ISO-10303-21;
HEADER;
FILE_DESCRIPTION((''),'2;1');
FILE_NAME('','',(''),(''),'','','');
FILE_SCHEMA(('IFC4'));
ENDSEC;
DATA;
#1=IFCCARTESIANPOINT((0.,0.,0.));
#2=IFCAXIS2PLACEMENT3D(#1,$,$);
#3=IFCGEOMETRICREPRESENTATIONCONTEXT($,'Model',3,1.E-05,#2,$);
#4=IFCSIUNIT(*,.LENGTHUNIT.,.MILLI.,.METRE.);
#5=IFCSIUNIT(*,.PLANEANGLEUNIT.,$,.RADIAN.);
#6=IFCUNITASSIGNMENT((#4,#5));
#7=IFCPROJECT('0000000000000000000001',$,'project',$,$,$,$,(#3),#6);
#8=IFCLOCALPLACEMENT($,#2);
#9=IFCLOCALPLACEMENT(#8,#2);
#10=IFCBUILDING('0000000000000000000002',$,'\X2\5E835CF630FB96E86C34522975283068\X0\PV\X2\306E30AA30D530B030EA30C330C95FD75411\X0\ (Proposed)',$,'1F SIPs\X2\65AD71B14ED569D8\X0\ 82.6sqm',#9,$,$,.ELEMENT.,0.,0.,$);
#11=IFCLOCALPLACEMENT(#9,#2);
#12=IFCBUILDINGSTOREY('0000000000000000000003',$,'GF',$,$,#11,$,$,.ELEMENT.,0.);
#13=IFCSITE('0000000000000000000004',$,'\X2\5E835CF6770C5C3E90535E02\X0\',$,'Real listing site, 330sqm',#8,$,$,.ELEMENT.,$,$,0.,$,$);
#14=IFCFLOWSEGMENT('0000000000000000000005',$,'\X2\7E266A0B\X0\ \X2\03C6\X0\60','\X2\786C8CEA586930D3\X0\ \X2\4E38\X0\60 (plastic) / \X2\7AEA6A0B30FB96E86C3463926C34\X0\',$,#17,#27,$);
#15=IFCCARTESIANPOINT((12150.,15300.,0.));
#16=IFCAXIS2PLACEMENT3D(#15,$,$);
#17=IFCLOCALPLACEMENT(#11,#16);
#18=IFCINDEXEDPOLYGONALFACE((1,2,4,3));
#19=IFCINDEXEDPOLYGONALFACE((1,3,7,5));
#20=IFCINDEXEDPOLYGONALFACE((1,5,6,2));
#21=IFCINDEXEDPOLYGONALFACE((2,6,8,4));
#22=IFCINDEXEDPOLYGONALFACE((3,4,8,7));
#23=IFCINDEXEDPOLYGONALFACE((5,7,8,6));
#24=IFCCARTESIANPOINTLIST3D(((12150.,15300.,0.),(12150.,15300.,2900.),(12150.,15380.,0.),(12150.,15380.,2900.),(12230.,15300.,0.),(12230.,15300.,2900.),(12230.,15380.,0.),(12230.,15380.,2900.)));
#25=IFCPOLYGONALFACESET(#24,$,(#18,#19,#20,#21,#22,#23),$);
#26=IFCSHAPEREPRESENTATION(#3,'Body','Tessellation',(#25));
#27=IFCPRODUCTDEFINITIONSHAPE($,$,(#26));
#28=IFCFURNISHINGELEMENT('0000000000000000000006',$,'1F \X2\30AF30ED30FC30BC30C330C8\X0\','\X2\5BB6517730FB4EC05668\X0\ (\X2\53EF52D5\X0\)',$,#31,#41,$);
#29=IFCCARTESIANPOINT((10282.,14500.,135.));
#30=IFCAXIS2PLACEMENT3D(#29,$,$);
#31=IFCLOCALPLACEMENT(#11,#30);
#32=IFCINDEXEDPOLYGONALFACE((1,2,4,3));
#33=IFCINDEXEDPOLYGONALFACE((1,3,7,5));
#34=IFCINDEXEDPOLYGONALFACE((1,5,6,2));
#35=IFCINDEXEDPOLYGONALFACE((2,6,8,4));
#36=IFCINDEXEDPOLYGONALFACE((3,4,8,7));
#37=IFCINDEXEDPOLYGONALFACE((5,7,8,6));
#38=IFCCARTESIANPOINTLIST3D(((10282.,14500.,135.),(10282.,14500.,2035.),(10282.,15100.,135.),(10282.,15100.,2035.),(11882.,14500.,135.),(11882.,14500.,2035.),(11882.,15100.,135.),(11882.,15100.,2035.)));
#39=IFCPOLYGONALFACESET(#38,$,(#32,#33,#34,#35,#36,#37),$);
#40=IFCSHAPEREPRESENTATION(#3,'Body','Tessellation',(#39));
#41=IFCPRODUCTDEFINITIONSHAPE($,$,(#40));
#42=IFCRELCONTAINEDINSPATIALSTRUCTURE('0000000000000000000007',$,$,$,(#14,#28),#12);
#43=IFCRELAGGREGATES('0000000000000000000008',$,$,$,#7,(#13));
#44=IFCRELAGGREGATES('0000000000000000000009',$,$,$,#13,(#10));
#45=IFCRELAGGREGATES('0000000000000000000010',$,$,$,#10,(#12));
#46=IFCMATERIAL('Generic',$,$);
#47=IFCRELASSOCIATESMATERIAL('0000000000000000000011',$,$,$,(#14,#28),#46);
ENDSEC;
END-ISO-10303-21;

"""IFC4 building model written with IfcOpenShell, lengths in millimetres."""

from ifc_helpers import new_model, si_unit, frame, frame_2d, origin, place, context, project, spatial, rectangle, extrude, material, element, save


model = new_model("IFC4")

# Units and contexts
model_context = context("Model", 3, precision=1e-05, world=origin())
ifc_project = project(units=[si_unit("LENGTHUNIT", "METRE", prefix="MILLI"), si_unit("PLANEANGLEUNIT", "RADIAN")], contexts=[model_context])

# Site, building, storey
site_placement = place(None, origin())
site = spatial("IfcSite", under=ifc_project, at=site_placement, Name="広島県尾道市", ObjectType="Real listing site, 330sqm", CompositionType="ELEMENT", RefElevation=0.0)
building_placement = place(site_placement, origin())
building = spatial("IfcBuilding", under=site, at=building_placement, Name="広島・雨水利用とPVのオフグリッド志向 (Proposed)", ObjectType="1F SIPs断熱仕様 82.6sqm", CompositionType="ELEMENT", ElevationOfRefHeight=0.0, ElevationOfTerrain=0.0)
storey_placement = place(building_placement, origin())
storey = spatial("IfcBuildingStorey", under=building, at=storey_placement, Name="GF", CompositionType="ELEMENT", Elevation=0.0)

# Shared definitions
ifc_material_1 = material(Name="Generic")

# Flow segment
flow_segment_placement = place(storey_placement, frame((12150.0, 15300.0, 0.0)))
element("IfcFlowSegment", 1, at=flow_segment_placement, inside=storey, material=ifc_material_1, Name="縦樋 φ60", Description="硬質塩ビ 丸60 (plastic) / 竪樋・雨水排水", context=model_context, shape_type="SweptSolid", body=[
    extrude(rectangle(XDim=80.0, YDim=80.0, at=frame_2d((40.0, 40.0))), frame((12150.0, 15300.0, 0.0)), (0.0, 0.0, 1.0), 2900.0),
])

# Furnishing element
furnishing_placement = place(storey_placement, frame((10282.0, 14500.0, 135.0)))
element("IfcFurnishingElement", 2, at=furnishing_placement, inside=storey, material=ifc_material_1, Name="1F クローゼット", Description="家具・什器 (可動)", context=model_context, shape_type="SweptSolid", body=[
    extrude(rectangle(XDim=1600.0, YDim=600.0, at=frame_2d((800.0, 300.0))), frame((10282.0, 14500.0, 135.0)), (0.0, 0.0, 1.0), 1900.0),
])

save(model, "model.ifc")
